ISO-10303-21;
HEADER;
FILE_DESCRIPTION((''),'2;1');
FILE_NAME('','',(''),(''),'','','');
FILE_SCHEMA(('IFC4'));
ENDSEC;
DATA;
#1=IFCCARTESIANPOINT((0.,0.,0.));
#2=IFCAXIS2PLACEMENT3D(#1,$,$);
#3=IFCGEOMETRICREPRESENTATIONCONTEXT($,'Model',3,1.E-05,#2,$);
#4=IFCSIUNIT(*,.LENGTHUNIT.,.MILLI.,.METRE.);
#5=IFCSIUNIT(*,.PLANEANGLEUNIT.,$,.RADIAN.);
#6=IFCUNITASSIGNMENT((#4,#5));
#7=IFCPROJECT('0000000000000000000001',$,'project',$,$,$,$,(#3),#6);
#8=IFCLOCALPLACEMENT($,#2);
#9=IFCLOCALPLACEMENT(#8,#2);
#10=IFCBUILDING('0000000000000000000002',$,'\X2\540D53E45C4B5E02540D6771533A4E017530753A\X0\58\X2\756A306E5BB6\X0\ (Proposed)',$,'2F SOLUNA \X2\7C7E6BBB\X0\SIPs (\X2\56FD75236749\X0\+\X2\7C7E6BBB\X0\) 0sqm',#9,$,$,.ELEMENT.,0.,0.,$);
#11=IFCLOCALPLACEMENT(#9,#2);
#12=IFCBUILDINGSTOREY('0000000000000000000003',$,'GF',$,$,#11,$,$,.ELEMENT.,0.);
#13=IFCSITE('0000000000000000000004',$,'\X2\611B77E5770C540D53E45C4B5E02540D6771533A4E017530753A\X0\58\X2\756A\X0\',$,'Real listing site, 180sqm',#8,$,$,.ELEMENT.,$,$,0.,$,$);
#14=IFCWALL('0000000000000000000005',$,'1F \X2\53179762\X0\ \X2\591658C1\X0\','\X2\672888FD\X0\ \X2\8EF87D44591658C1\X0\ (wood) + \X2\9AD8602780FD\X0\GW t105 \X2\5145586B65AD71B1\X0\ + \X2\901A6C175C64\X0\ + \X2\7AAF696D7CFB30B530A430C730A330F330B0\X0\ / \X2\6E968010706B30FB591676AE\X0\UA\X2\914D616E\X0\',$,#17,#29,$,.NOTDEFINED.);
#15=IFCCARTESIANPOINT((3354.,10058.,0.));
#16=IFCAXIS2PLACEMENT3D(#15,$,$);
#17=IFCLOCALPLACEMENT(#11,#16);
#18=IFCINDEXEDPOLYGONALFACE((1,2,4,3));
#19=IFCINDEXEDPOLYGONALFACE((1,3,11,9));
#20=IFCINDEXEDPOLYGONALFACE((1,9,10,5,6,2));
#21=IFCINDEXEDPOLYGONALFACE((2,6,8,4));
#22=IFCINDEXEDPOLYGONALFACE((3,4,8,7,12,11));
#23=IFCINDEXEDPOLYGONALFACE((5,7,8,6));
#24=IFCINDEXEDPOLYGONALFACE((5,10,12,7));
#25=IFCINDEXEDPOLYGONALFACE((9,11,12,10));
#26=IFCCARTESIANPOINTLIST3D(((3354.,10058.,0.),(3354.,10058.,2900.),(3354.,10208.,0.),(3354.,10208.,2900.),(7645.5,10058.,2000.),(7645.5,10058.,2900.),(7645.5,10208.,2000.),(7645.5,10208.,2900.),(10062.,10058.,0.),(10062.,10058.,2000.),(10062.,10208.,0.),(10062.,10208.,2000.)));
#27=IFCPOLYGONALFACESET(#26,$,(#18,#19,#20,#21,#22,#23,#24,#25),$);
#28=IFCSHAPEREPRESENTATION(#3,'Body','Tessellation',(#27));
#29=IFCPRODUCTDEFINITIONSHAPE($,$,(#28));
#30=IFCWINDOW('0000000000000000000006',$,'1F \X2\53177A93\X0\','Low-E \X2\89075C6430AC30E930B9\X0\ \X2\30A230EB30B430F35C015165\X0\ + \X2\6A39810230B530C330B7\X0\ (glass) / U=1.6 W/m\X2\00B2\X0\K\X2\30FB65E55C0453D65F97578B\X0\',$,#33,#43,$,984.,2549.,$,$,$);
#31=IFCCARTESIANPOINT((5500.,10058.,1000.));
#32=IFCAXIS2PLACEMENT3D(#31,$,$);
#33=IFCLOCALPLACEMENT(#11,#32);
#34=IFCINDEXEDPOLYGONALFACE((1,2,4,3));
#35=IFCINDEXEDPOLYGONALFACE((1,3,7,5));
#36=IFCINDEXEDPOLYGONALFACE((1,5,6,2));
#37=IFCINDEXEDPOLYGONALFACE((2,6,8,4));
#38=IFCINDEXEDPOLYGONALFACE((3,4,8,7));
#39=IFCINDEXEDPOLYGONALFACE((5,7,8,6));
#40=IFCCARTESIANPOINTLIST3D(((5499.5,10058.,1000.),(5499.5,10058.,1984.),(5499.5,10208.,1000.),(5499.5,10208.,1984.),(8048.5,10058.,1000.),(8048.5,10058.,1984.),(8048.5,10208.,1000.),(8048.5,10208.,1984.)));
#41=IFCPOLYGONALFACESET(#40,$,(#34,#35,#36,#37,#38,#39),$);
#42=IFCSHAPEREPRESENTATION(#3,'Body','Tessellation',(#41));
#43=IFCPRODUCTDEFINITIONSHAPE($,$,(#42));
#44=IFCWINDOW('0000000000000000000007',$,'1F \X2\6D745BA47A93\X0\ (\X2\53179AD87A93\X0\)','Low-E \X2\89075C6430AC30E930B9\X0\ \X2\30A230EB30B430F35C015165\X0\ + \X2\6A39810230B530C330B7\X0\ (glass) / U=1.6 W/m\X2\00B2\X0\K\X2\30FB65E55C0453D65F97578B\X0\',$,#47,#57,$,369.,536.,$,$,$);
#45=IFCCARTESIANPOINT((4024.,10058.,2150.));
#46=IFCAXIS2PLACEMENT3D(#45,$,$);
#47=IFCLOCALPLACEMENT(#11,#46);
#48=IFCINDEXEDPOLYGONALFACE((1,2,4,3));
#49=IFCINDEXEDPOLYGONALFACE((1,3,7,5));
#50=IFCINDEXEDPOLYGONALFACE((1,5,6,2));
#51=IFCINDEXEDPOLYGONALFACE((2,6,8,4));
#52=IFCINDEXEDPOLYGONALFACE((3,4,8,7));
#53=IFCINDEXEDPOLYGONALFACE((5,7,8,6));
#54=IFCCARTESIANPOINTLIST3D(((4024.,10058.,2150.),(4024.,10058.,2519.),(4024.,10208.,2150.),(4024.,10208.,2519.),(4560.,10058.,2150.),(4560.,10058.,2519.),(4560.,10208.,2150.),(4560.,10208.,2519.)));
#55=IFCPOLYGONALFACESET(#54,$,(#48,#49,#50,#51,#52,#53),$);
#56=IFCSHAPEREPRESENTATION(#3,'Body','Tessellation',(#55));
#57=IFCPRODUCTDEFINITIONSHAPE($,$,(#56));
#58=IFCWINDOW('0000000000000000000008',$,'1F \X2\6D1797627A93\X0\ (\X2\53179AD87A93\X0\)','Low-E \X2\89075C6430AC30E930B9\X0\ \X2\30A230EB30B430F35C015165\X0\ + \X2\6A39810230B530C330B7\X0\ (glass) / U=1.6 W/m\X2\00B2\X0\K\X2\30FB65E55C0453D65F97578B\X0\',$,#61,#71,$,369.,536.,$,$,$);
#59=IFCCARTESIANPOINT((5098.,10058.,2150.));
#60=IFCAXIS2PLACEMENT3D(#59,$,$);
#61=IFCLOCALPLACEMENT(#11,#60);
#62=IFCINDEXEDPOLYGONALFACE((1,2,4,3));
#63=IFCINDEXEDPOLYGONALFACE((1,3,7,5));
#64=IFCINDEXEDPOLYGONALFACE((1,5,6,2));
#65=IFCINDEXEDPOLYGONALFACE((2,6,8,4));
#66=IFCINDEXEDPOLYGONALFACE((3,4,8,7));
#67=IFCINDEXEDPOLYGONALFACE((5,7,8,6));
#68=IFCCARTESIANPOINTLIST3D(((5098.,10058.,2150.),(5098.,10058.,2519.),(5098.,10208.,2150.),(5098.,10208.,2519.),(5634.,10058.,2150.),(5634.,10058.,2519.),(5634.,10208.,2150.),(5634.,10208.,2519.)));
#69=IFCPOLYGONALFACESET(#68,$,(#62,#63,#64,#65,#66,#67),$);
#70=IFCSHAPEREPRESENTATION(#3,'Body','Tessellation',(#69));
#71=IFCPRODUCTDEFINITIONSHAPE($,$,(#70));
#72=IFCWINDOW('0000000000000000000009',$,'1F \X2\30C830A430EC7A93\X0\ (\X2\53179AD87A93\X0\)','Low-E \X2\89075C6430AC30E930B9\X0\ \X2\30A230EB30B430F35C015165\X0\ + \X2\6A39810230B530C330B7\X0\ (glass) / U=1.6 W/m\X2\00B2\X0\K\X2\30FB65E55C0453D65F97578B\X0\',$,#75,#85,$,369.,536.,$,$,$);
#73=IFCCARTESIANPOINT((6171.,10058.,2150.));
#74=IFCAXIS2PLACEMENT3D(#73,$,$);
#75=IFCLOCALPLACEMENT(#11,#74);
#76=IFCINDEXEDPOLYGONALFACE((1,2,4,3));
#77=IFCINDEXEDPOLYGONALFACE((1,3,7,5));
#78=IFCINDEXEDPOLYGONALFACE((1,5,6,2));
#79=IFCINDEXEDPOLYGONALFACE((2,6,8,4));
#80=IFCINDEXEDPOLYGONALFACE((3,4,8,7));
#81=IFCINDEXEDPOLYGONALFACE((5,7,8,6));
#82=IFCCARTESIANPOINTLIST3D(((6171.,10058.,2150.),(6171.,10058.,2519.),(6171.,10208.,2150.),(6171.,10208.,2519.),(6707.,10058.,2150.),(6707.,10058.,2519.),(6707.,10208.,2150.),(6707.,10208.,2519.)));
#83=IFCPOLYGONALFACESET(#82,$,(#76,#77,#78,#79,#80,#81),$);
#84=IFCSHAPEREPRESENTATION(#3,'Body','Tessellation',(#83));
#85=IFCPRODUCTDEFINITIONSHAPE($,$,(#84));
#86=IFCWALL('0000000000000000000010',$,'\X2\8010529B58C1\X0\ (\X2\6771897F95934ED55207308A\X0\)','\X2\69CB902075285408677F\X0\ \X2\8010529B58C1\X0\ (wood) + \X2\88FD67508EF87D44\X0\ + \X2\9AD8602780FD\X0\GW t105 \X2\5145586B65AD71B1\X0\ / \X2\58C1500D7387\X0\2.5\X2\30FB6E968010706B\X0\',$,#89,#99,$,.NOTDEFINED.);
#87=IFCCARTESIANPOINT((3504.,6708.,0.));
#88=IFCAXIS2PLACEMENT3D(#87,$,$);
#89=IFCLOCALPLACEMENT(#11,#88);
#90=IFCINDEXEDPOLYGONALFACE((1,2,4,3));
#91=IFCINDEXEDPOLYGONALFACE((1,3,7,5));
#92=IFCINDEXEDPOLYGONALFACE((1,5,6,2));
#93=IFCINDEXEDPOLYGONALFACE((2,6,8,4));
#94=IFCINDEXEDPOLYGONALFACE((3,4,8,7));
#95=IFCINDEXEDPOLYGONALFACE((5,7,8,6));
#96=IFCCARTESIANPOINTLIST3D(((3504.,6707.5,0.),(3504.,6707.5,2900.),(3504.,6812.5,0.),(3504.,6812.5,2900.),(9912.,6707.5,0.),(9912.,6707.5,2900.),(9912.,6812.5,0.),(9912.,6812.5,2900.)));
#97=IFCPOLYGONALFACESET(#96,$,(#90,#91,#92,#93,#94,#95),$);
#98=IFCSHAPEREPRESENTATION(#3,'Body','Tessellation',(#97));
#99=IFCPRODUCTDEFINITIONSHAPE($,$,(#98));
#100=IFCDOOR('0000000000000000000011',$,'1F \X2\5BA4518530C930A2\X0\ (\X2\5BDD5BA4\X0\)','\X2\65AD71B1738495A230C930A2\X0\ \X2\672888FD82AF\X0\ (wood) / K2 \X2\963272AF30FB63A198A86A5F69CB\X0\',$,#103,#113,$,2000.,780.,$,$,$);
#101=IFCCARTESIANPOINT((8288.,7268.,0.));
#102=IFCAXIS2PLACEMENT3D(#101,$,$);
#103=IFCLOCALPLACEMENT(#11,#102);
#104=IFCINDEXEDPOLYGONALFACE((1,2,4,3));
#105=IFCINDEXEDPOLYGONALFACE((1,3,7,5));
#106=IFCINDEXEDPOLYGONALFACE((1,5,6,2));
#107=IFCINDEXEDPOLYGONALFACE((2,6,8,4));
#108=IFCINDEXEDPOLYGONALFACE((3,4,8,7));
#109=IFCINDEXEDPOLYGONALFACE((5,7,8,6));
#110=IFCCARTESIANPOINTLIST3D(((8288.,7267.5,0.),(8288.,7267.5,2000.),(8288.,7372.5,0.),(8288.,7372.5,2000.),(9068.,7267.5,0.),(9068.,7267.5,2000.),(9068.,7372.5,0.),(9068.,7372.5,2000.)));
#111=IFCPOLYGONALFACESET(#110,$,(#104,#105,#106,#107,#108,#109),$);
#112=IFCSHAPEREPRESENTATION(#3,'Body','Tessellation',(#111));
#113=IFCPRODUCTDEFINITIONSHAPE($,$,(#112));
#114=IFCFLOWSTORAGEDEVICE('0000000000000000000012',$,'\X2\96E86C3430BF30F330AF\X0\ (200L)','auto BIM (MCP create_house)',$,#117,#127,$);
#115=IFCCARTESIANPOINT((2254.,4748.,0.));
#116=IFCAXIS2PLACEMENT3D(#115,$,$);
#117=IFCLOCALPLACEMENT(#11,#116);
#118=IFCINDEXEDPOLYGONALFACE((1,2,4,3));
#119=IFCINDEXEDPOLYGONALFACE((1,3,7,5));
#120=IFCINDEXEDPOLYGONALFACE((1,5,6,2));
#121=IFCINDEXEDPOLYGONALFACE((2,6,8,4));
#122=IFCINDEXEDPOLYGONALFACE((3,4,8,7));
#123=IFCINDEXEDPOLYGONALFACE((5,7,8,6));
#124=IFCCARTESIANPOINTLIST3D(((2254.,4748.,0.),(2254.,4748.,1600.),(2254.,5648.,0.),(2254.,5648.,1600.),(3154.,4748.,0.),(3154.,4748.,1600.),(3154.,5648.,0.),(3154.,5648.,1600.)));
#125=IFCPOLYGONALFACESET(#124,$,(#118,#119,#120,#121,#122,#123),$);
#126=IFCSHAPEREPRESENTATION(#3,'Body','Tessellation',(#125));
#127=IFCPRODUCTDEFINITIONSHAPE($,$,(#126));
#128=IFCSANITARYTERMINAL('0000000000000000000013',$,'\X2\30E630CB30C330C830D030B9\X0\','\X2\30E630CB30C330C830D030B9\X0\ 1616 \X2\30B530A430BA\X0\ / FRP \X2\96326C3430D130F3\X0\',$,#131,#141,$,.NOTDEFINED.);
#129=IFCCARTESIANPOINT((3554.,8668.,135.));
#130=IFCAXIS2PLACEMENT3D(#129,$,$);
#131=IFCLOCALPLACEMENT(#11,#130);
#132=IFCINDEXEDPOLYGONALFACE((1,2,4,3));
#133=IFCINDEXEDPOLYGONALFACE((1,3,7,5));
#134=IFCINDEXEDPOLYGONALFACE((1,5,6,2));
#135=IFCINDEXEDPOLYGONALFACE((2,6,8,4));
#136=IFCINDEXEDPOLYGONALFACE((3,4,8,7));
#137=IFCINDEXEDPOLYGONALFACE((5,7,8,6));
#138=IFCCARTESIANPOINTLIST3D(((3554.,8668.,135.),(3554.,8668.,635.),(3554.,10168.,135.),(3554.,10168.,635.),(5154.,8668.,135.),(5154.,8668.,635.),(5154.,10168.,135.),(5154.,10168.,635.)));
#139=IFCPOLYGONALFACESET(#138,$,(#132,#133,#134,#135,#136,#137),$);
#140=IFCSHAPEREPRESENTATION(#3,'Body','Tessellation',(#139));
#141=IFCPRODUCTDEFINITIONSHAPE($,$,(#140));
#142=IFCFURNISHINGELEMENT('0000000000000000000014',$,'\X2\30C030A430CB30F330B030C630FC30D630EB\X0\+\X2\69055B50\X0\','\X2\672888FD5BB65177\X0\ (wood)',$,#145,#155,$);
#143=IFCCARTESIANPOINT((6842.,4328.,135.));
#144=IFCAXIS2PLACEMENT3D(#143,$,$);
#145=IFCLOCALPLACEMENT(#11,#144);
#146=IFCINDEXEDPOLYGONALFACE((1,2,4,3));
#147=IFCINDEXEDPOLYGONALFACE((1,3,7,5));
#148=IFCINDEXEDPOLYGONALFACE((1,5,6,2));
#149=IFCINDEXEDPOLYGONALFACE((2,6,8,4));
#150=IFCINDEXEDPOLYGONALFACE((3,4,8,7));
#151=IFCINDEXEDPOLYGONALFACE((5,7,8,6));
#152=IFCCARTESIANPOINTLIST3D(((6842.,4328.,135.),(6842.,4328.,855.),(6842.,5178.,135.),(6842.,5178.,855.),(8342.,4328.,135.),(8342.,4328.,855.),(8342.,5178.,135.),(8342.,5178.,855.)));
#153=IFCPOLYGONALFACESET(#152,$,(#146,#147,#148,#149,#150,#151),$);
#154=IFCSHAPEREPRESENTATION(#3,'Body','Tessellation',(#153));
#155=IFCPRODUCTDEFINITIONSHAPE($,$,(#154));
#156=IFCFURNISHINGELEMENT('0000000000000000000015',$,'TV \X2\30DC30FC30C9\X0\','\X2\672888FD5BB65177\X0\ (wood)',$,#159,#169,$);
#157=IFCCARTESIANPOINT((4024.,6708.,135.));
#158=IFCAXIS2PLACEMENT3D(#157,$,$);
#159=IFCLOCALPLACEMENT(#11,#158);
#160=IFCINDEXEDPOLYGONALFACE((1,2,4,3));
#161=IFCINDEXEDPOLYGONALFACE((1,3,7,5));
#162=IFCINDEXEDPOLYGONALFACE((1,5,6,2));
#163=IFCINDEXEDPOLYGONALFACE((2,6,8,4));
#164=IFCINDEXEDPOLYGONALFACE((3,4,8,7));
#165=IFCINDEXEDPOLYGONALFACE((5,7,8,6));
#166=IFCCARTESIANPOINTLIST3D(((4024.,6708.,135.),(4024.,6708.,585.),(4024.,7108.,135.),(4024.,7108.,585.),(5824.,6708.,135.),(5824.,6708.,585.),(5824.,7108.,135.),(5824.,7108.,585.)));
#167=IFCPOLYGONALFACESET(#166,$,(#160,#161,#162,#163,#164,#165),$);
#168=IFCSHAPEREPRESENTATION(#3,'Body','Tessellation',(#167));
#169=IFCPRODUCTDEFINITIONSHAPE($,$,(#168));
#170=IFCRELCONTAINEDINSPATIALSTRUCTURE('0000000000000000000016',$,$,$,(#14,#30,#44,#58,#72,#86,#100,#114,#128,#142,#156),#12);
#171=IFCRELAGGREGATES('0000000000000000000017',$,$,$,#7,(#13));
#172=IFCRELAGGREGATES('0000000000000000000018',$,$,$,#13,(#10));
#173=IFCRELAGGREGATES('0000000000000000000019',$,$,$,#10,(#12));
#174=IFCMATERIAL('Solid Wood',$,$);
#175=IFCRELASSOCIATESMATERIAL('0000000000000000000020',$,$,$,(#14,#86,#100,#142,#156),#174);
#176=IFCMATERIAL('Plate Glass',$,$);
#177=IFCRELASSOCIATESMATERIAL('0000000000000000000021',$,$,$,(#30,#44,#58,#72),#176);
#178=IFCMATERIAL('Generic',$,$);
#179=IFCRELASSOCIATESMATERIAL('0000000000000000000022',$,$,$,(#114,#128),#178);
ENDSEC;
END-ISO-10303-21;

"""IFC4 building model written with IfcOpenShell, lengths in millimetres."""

from ifc_helpers import new_model, si_unit, frame, frame_2d, origin, place, context, project, spatial, rectangle, extrude, material, element, fill, save


model = new_model("IFC4")

# Units and contexts
model_context = context("Model", 3, precision=1e-05, world=origin())
ifc_project = project(units=[si_unit("LENGTHUNIT", "METRE", prefix="MILLI"), si_unit("PLANEANGLEUNIT", "RADIAN")], contexts=[model_context])

# Site, building, storey
site_placement = place(None, origin())
site = spatial("IfcSite", under=ifc_project, at=site_placement, Name="愛知県名古屋市名東区丁田町58番", ObjectType="Real listing site, 180sqm", CompositionType="ELEMENT", RefElevation=0.0)
building_placement = place(site_placement, origin())
building = spatial("IfcBuilding", under=site, at=building_placement, Name="名古屋市名東区丁田町58番の家 (Proposed)", ObjectType="2F SOLUNA 籾殻SIPs (国産杉+籾殻) 0sqm", CompositionType="ELEMENT", ElevationOfRefHeight=0.0, ElevationOfTerrain=0.0)
storey_placement = place(building_placement, origin())
storey = spatial("IfcBuildingStorey", under=building, at=storey_placement, Name="GF", CompositionType="ELEMENT", Elevation=0.0)

# Wall, openings, windows
ifc_material_1 = material(Name="Solid Wood")
wall_1_placement = place(storey_placement, frame((3354.0, 10058.0, 0.0)))
wall_1 = element("IfcWall", 1, at=wall_1_placement, inside=storey, material=ifc_material_1, Name="1F 北面 外壁", Description="木製 軸組外壁 (wood) + 高性能GW t105 充填断熱 + 通気層 + 窯業系サイディング / 準耐火・外皮UA配慮", PredefinedType="NOTDEFINED", context=model_context, shape_type="SweptSolid", body=[
    extrude(rectangle(XDim=6708.0, YDim=150.0, at=frame_2d((3354.0, 75.0))), frame((3354.0, 10058.0, 0.0)), (0.0, 0.0, 1.0), 2900.0),
])
opening_1_placement = place(storey_placement, frame((5500.0, 10058.0, 1000.0)))
opening_1 = element("IfcOpeningElement", 2, at=opening_1_placement, cuts=wall_1, PredefinedType="NOTDEFINED", context=model_context, shape_type="SweptSolid", body=[
    extrude(rectangle(XDim=2549.0, YDim=150.0, at=frame_2d((1274.0, 75.0))), frame((5500.0, 10058.0, 1000.0)), (0.0, 0.0, 1.0), 984.0),
])
opening_2_placement = place(storey_placement, frame((4024.0, 10058.0, 2150.0)))
opening_2 = element("IfcOpeningElement", 3, at=opening_2_placement, cuts=wall_1, PredefinedType="NOTDEFINED", context=model_context, shape_type="SweptSolid", body=[
    extrude(rectangle(XDim=536.0, YDim=150.0, at=frame_2d((268.0, 75.0))), frame((4024.0, 10058.0, 2150.0)), (0.0, 0.0, 1.0), 369.0),
])
opening_3_placement = place(storey_placement, frame((5098.0, 10058.0, 2150.0)))
opening_3 = element("IfcOpeningElement", 4, at=opening_3_placement, cuts=wall_1, PredefinedType="NOTDEFINED", context=model_context, shape_type="SweptSolid", body=[
    extrude(rectangle(XDim=536.0, YDim=150.0, at=frame_2d((268.0, 75.0))), frame((5098.0, 10058.0, 2150.0)), (0.0, 0.0, 1.0), 369.0),
])
opening_4_placement = place(storey_placement, frame((6171.0, 10058.0, 2150.0)))
opening_4 = element("IfcOpeningElement", 5, at=opening_4_placement, cuts=wall_1, PredefinedType="NOTDEFINED", context=model_context, shape_type="SweptSolid", body=[
    extrude(rectangle(XDim=536.0, YDim=150.0, at=frame_2d((268.0, 75.0))), frame((6171.0, 10058.0, 2150.0)), (0.0, 0.0, 1.0), 369.0),
])
ifc_material_2 = material(Name="Plate Glass")
window_1_placement = place(storey_placement, frame((5500.0, 10058.0, 1000.0)))
window_1 = element("IfcWindow", 6, at=window_1_placement, inside=storey, material=ifc_material_2, Name="1F 北窓", Description="Low-E 複層ガラス アルゴン封入 + 樹脂サッシ (glass) / U=1.6 W/m²K・日射取得型", OverallHeight=984.0, OverallWidth=2549.0, context=model_context, shape_type="SweptSolid", body=[
    extrude(rectangle(XDim=2549.0, YDim=150.0, at=frame_2d((1274.0, 75.0))), frame((5500.0, 10058.0, 1000.0)), (0.0, 0.0, 1.0), 984.0),
])
fill(opening_1, window_1)
window_2_placement = place(storey_placement, frame((4024.0, 10058.0, 2150.0)))
window_2 = element("IfcWindow", 7, at=window_2_placement, inside=storey, material=ifc_material_2, Name="1F 浴室窓 (北高窓)", Description="Low-E 複層ガラス アルゴン封入 + 樹脂サッシ (glass) / U=1.6 W/m²K・日射取得型", OverallHeight=369.0, OverallWidth=536.0, context=model_context, shape_type="SweptSolid", body=[
    extrude(rectangle(XDim=536.0, YDim=150.0, at=frame_2d((268.0, 75.0))), frame((4024.0, 10058.0, 2150.0)), (0.0, 0.0, 1.0), 369.0),
])
fill(opening_2, window_2)
window_3_placement = place(storey_placement, frame((5098.0, 10058.0, 2150.0)))
window_3 = element("IfcWindow", 8, at=window_3_placement, inside=storey, material=ifc_material_2, Name="1F 洗面窓 (北高窓)", Description="Low-E 複層ガラス アルゴン封入 + 樹脂サッシ (glass) / U=1.6 W/m²K・日射取得型", OverallHeight=369.0, OverallWidth=536.0, context=model_context, shape_type="SweptSolid", body=[
    extrude(rectangle(XDim=536.0, YDim=150.0, at=frame_2d((268.0, 75.0))), frame((5098.0, 10058.0, 2150.0)), (0.0, 0.0, 1.0), 369.0),
])
fill(opening_3, window_3)
window_4_placement = place(storey_placement, frame((6171.0, 10058.0, 2150.0)))
window_4 = element("IfcWindow", 9, at=window_4_placement, inside=storey, material=ifc_material_2, Name="1F トイレ窓 (北高窓)", Description="Low-E 複層ガラス アルゴン封入 + 樹脂サッシ (glass) / U=1.6 W/m²K・日射取得型", OverallHeight=369.0, OverallWidth=536.0, context=model_context, shape_type="SweptSolid", body=[
    extrude(rectangle(XDim=536.0, YDim=150.0, at=frame_2d((268.0, 75.0))), frame((6171.0, 10058.0, 2150.0)), (0.0, 0.0, 1.0), 369.0),
])
fill(opening_4, window_4)

# Wall
wall_2_placement = place(storey_placement, frame((3504.0, 6708.0, 0.0)))
element("IfcWall", 10, at=wall_2_placement, inside=storey, material=ifc_material_1, Name="耐力壁 (東西間仕切り)", Description="構造用合板 耐力壁 (wood) + 製材軸組 + 高性能GW t105 充填断熱 / 壁倍率2.5・準耐火", PredefinedType="NOTDEFINED", context=model_context, shape_type="SweptSolid", body=[
    extrude(rectangle(XDim=6408.0, YDim=105.0, at=frame_2d((3204.0, 52.0))), frame((3504.0, 6708.0, 0.0)), (0.0, 0.0, 1.0), 2900.0),
])

# Door
door_1_placement = place(storey_placement, frame((8288.0, 7268.0, 0.0)))
element("IfcDoor", 11, at=door_1_placement, inside=storey, material=ifc_material_1, Name="1F 室内ドア (寝室)", Description="断熱玄関ドア 木製芯 (wood) / K2 防犯・採風機構", OverallHeight=2000.0, OverallWidth=780.0, context=model_context, shape_type="SweptSolid", body=[
    extrude(rectangle(XDim=780.0, YDim=105.0, at=frame_2d((390.0, 52.0))), frame((8288.0, 7268.0, 0.0)), (0.0, 0.0, 1.0), 2000.0),
])

# Flow storage device
ifc_material_3 = material(Name="Generic")
flow_storage_device_placement = place(storey_placement, frame((2254.0, 4748.0, 0.0)))
element("IfcFlowStorageDevice", 12, at=flow_storage_device_placement, inside=storey, material=ifc_material_3, Name="雨水タンク (200L)", Description="auto BIM (MCP create_house)", context=model_context, shape_type="SweptSolid", body=[
    extrude(rectangle(XDim=900.0, YDim=900.0, at=frame_2d((450.0, 450.0))), frame((2254.0, 4748.0, 0.0)), (0.0, 0.0, 1.0), 1600.0),
])

# Sanitary terminal
sanitary_terminal_placement = place(storey_placement, frame((3554.0, 8668.0, 135.0)))
element("IfcSanitaryTerminal", 13, at=sanitary_terminal_placement, inside=storey, material=ifc_material_3, Name="ユニットバス", Description="ユニットバス 1616 サイズ / FRP 防水パン", PredefinedType="NOTDEFINED", context=model_context, shape_type="SweptSolid", body=[
    extrude(rectangle(XDim=1600.0, YDim=1500.0, at=frame_2d((800.0, 750.0))), frame((3554.0, 8668.0, 135.0)), (0.0, 0.0, 1.0), 500.0),
])

# Furnishing elements
furnishing_1_placement = place(storey_placement, frame((6842.0, 4328.0, 135.0)))
element("IfcFurnishingElement", 14, at=furnishing_1_placement, inside=storey, material=ifc_material_1, Name="ダイニングテーブル+椅子", Description="木製家具 (wood)", context=model_context, shape_type="SweptSolid", body=[
    extrude(rectangle(XDim=1500.0, YDim=850.0, at=frame_2d((750.0, 425.0))), frame((6842.0, 4328.0, 135.0)), (0.0, 0.0, 1.0), 720.0),
])
furnishing_2_placement = place(storey_placement, frame((4024.0, 6708.0, 135.0)))
element("IfcFurnishingElement", 15, at=furnishing_2_placement, inside=storey, material=ifc_material_1, Name="TV ボード", Description="木製家具 (wood)", context=model_context, shape_type="SweptSolid", body=[
    extrude(rectangle(XDim=1800.0, YDim=400.0, at=frame_2d((900.0, 200.0))), frame((4024.0, 6708.0, 135.0)), (0.0, 0.0, 1.0), 450.0),
])

save(model, "model.ifc")
